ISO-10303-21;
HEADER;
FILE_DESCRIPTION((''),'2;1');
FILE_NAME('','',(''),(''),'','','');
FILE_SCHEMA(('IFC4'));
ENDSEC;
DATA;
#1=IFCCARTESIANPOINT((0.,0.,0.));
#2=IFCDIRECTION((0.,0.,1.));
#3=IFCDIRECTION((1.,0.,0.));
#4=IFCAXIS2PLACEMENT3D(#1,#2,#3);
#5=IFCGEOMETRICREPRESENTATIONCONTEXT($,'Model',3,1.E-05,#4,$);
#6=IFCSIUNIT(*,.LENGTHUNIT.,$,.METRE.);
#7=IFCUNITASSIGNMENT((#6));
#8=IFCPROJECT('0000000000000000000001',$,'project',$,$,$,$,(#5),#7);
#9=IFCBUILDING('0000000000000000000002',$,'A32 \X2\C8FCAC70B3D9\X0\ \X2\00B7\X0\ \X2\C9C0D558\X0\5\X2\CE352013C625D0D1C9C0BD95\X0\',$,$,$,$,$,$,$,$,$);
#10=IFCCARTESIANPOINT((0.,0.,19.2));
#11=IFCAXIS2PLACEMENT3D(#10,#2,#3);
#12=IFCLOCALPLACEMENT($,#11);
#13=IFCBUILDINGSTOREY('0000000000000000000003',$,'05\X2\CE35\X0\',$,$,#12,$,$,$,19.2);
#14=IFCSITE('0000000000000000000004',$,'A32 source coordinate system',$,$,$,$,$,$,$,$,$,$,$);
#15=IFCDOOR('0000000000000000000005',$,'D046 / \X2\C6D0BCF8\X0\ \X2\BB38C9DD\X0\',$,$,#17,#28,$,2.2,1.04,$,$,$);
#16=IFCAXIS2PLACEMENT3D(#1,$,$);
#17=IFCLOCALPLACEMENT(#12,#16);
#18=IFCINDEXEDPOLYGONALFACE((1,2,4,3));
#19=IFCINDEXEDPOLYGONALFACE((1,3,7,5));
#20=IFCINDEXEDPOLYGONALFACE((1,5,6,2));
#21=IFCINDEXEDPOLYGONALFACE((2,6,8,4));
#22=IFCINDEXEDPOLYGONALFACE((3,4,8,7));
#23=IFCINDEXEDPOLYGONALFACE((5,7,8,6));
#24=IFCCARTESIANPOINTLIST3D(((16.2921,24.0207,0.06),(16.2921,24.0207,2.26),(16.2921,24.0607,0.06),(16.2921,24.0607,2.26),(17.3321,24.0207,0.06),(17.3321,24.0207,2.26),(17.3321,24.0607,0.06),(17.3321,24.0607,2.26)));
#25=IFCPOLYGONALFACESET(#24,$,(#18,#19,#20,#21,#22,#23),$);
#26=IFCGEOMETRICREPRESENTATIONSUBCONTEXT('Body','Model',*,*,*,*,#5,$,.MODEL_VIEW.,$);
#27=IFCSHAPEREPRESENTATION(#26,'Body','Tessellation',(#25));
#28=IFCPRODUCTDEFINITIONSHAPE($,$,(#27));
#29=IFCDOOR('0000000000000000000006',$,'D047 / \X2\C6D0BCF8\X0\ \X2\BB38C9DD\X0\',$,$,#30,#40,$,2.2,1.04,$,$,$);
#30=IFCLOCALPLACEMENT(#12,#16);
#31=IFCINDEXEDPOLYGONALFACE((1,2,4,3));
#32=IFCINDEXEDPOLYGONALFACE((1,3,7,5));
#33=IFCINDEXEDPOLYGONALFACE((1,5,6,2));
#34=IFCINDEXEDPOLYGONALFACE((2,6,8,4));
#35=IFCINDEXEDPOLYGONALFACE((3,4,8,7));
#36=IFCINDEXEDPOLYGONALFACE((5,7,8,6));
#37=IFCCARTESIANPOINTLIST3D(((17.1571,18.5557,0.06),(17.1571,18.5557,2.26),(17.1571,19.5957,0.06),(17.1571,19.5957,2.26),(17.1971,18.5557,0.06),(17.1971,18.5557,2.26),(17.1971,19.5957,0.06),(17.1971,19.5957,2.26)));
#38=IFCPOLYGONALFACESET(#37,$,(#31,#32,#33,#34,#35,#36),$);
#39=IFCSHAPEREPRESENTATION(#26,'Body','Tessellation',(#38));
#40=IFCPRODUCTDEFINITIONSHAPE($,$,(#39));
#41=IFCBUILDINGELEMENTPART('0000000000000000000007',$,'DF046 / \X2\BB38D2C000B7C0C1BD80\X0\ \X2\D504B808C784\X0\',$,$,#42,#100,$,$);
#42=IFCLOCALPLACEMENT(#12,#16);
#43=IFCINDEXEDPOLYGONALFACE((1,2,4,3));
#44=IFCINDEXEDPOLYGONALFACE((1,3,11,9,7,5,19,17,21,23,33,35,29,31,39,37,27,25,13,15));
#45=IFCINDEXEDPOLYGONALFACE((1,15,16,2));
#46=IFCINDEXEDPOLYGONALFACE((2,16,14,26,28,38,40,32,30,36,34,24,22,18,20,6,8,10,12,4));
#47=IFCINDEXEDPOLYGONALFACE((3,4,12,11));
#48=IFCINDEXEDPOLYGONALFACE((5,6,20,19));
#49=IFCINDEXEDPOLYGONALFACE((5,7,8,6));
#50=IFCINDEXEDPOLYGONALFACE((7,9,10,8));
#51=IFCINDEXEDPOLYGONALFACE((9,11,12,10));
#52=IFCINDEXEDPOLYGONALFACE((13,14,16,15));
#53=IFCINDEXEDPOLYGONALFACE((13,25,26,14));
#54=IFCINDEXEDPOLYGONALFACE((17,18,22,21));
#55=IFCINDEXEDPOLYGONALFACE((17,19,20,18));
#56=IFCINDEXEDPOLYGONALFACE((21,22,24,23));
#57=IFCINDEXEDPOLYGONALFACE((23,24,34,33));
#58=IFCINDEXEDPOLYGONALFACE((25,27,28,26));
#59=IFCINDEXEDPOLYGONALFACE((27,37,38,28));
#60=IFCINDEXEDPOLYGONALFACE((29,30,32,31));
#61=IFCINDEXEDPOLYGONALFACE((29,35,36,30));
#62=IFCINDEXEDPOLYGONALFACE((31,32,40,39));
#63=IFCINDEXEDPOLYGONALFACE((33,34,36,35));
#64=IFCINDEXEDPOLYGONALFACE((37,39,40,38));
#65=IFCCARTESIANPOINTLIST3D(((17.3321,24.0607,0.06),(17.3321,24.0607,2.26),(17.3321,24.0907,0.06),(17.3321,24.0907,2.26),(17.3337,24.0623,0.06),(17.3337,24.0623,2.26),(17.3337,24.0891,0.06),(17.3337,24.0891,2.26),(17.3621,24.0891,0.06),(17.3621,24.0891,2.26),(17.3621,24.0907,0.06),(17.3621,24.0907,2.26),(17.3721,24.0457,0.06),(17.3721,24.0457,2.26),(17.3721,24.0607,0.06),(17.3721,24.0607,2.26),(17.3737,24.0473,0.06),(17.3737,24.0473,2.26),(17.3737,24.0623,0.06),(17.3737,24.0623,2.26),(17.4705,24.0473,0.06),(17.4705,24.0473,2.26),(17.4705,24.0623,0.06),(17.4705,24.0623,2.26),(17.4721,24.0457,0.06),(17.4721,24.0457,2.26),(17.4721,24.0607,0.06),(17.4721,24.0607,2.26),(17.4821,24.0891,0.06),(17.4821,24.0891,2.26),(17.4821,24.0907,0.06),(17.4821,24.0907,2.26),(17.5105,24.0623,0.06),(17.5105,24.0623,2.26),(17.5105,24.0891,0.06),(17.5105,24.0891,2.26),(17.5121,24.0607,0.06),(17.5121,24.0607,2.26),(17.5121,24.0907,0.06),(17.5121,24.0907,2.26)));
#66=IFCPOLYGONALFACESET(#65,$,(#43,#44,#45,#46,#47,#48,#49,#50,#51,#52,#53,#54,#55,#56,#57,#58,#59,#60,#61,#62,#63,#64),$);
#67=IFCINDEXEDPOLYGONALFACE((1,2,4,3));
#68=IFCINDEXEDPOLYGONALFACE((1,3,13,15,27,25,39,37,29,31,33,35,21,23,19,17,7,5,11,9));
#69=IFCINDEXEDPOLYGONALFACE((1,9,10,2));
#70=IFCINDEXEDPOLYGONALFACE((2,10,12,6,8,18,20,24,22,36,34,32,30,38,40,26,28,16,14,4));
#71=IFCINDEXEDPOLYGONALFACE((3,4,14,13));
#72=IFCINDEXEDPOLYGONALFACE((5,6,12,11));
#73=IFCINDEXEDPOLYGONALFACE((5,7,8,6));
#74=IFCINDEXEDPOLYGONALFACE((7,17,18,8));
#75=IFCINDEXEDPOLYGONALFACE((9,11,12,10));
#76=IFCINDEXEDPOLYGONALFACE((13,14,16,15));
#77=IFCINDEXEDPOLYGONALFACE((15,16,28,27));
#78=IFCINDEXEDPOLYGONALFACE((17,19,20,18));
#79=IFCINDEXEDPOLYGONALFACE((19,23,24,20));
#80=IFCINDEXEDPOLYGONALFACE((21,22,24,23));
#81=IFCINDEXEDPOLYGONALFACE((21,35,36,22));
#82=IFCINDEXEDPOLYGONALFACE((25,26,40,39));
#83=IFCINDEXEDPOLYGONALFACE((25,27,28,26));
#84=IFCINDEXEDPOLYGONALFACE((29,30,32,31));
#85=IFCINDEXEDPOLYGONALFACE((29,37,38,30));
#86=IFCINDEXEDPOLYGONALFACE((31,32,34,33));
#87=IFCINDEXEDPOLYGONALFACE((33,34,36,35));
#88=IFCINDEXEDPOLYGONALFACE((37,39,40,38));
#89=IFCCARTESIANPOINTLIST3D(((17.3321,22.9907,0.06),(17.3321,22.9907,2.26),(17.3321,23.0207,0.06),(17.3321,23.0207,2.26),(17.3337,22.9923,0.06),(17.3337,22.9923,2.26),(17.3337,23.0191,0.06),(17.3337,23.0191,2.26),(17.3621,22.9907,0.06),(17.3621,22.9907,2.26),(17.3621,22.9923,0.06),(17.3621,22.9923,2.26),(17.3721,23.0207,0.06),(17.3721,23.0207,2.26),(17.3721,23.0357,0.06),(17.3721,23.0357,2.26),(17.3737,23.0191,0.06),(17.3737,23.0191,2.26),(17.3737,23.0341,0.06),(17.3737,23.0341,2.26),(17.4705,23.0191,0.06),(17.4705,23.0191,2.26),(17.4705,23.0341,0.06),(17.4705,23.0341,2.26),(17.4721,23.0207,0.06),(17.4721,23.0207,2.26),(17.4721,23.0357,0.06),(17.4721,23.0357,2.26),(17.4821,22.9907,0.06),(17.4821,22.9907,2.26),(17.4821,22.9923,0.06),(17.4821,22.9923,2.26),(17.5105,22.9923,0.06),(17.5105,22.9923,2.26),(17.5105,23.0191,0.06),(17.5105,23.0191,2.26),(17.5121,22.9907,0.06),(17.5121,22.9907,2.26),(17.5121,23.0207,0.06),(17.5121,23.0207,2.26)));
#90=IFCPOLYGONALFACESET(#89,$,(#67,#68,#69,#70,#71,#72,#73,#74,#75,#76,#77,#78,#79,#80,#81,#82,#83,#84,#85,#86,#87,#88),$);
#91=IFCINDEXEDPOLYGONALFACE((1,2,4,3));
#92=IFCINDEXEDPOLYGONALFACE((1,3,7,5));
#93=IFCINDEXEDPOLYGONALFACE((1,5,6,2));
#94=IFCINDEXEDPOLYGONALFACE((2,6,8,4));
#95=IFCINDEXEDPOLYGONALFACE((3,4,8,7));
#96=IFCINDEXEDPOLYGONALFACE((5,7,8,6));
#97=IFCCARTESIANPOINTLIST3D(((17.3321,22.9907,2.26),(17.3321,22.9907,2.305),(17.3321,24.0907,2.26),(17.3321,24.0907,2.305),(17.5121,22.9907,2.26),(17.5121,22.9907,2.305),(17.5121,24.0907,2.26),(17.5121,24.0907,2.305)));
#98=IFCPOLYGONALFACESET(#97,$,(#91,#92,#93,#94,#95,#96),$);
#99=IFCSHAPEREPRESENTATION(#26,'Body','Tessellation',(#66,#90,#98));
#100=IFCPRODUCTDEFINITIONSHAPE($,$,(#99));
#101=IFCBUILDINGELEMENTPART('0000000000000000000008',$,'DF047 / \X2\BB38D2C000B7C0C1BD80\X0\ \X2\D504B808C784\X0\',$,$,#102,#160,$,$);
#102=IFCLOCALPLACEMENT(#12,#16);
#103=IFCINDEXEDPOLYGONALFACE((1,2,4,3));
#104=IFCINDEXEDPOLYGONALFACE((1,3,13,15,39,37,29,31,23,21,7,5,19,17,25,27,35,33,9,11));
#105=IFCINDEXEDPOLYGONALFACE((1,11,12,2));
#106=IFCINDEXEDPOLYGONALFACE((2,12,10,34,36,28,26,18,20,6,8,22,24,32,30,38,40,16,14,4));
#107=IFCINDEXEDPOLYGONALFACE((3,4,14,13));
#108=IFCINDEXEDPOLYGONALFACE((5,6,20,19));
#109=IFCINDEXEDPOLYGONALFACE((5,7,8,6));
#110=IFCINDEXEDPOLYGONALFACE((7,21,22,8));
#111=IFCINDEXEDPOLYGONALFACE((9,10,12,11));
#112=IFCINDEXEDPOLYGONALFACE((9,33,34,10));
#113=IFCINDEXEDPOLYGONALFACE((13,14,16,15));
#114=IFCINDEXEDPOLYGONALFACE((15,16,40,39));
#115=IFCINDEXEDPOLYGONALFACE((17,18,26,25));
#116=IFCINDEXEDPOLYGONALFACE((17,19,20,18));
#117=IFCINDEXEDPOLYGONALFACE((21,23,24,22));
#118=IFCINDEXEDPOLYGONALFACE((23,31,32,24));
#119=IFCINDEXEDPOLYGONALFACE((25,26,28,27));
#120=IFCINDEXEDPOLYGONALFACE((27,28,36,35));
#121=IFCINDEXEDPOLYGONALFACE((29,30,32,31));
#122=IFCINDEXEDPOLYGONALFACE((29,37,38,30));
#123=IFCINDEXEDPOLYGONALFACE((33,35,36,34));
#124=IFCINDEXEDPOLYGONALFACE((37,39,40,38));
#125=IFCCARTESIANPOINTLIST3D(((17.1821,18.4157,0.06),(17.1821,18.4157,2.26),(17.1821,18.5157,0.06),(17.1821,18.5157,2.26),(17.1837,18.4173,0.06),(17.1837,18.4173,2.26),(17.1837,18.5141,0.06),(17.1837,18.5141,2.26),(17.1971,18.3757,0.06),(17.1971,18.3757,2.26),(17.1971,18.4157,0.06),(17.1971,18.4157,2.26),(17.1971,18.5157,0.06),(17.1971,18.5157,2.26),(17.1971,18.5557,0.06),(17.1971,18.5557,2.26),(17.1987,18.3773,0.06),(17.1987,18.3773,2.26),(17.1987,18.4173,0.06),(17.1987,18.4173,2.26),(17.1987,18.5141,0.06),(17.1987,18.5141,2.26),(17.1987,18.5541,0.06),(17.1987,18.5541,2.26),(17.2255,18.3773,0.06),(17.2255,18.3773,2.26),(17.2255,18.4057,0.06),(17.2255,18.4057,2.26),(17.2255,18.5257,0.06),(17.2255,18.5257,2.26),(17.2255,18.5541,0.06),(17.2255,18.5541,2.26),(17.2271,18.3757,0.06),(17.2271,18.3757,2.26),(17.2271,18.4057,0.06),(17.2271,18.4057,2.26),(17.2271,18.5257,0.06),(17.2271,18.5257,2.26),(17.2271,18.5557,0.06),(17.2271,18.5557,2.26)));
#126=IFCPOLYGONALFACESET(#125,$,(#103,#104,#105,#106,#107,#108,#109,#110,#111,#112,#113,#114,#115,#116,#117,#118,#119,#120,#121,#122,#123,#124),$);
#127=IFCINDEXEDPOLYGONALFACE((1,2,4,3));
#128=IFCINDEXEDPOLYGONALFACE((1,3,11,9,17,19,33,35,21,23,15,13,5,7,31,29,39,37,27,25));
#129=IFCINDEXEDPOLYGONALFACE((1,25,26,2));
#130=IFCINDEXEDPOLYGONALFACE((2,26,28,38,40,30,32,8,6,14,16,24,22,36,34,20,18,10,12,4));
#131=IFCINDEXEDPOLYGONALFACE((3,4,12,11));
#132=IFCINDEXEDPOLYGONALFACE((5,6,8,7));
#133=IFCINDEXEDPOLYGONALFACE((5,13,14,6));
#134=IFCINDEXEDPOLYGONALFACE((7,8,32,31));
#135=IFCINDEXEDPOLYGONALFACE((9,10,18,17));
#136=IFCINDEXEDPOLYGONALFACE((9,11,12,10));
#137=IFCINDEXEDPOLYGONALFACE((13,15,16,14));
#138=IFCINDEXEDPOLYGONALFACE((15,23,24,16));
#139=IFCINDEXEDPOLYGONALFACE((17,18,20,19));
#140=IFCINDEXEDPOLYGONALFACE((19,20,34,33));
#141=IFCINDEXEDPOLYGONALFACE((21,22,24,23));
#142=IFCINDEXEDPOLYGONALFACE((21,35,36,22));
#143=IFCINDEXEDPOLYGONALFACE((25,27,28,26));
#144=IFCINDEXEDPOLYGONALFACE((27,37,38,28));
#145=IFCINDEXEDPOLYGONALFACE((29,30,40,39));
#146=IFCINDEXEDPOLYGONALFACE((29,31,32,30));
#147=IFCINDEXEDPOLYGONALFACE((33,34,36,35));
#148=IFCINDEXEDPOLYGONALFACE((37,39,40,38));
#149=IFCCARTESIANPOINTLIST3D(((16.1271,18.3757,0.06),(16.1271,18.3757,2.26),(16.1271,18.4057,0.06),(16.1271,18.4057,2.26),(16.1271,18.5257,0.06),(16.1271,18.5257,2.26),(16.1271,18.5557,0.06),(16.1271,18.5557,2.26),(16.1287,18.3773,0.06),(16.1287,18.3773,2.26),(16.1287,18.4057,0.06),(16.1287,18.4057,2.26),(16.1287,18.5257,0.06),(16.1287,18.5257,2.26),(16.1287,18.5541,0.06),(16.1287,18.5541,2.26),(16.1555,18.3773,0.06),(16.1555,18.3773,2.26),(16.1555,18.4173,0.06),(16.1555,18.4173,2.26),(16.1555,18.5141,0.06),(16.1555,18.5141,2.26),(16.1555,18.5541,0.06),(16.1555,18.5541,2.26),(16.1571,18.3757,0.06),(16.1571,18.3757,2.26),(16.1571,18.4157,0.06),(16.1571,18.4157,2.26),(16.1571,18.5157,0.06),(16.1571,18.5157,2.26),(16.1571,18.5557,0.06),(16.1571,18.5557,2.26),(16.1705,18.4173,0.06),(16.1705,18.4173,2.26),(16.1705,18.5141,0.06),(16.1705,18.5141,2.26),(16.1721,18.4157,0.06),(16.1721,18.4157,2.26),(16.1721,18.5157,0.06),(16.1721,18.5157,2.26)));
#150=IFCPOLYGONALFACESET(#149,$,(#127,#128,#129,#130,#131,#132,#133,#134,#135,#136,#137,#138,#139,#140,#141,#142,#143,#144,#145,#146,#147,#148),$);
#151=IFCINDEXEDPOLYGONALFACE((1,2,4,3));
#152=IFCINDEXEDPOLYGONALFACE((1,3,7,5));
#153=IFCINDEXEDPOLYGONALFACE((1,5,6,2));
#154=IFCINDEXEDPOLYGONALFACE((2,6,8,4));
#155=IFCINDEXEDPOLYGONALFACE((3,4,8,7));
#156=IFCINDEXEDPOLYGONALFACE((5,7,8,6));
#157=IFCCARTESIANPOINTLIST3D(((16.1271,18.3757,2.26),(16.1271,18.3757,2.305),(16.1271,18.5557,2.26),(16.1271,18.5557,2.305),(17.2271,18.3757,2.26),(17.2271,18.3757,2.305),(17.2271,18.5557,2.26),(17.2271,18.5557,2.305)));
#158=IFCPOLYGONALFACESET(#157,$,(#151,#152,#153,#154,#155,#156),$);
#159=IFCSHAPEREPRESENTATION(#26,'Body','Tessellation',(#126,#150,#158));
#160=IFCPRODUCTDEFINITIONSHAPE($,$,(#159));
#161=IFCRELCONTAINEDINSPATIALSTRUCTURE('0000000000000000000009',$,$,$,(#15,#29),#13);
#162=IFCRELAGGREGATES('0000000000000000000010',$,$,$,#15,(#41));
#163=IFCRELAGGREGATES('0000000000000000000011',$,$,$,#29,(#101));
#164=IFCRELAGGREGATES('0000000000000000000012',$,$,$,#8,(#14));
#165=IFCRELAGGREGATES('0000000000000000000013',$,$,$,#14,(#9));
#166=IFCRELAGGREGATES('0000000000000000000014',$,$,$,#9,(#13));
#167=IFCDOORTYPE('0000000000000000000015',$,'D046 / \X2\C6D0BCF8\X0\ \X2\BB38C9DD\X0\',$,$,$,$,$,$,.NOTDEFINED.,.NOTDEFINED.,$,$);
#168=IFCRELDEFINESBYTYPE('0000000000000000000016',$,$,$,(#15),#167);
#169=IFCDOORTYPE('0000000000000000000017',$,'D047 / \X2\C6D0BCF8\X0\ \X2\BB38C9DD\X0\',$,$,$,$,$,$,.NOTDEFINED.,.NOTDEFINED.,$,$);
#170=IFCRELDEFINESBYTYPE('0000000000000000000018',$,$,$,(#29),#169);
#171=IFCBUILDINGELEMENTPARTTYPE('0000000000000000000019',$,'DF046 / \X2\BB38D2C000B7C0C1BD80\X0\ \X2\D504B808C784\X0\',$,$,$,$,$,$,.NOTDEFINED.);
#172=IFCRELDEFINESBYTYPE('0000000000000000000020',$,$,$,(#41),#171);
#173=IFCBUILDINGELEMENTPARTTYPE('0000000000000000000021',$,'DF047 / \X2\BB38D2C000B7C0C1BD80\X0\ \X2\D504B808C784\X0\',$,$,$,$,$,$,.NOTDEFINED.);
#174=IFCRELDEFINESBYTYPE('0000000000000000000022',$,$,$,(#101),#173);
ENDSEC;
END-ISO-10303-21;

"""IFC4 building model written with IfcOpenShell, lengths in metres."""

from ifc_helpers import new_model, si_unit, frame, origin, origin_with_axes, place, context, subcontext, project, spatial, polyline, outline, extrude, source, transform, mapped, type_object, type_shapes, element, aggregate, save


model = new_model("IFC4")

# Units and contexts
model_context = context("Model", 3, precision=1e-05, world=origin_with_axes())
body_context = subcontext(model_context, "Body", "Model", "MODEL_VIEW")
ifc_project = project(units=[si_unit("LENGTHUNIT", "METRE")], contexts=[model_context])

# Site, building, storey
storey_placement = place(None, frame((0.0, 0.0, 19.2), z_axis=(0.0, 0.0, 1.0), x_axis=(1.0, 0.0, 0.0)))
site = spatial("IfcSite", under=ifc_project, Name="A32 source coordinate system")
building = spatial("IfcBuilding", under=site, Name="A32 주거동 · 지하5층–옥탑지붕")
storey = spatial("IfcBuildingStorey", under=building, at=storey_placement, Name="05층", Elevation=19.2)

# Doors
door_type_1 = type_object("IfcDoorType", Name="D046 / 원본 문짝", OperationType="NOTDEFINED", PredefinedType="NOTDEFINED")
shared_shape_1 = source(origin(), body_context, "Body", "SweptSolid", [
    extrude(outline(polyline([(17.3321, 24.0607), (17.3321, 24.0207), (16.2921, 24.0207), (16.2921, 24.0607), (17.3321, 24.0607)])), frame((0.0, 0.0, 0.06)), (0.0, 0.0, 1.0), 2.2),
])
type_shapes(door_type_1, [shared_shape_1])
door_1_placement = place(storey_placement, origin_with_axes())
door_1 = element("IfcDoor", 1, at=door_1_placement, inside=storey, type_object=door_type_1, Name="D046 / 원본 문짝", OverallHeight=2.2, OverallWidth=1.04, context=body_context, shape_type="MappedRepresentation", body=[
    mapped(shared_shape_1, transform((0.0, 0.0, 0.0), scale=1.0)),
])
door_type_2 = type_object("IfcDoorType", Name="D047 / 원본 문짝", OperationType="NOTDEFINED", PredefinedType="NOTDEFINED")
shared_shape_2 = source(origin(), body_context, "Body", "SweptSolid", [
    extrude(outline(polyline([(17.1971, 18.5557), (17.1571, 18.5557), (17.1571, 19.5957), (17.1971, 19.5957), (17.1971, 18.5557)])), frame((0.0, 0.0, 0.06)), (0.0, 0.0, 1.0), 2.2),
])
type_shapes(door_type_2, [shared_shape_2])
door_2_placement = place(storey_placement, origin_with_axes())
door_2 = element("IfcDoor", 2, at=door_2_placement, inside=storey, type_object=door_type_2, Name="D047 / 원본 문짝", OverallHeight=2.2, OverallWidth=1.04, context=body_context, shape_type="MappedRepresentation", body=[
    mapped(shared_shape_2, transform((0.0, 0.0, 0.0), scale=1.0)),
])

# Building element parts
building_element_part_type_1 = type_object("IfcBuildingElementPartType", Name="DF046 / 문틀·상부 프레임", PredefinedType="NOTDEFINED")
shared_shape_3 = source(origin(), body_context, "Body", "SweptSolid", [
    extrude(outline(polyline([(17.3337, 24.0891), (17.3337, 24.0623), (17.3737, 24.0623), (17.3737, 24.0473), (17.4705, 24.0473), (17.4705, 24.0623), (17.5105, 24.0623), (17.5105, 24.0891), (17.4821, 24.0891), (17.4821, 24.0907), (17.5121, 24.0907), (17.5121, 24.0607), (17.4721, 24.0607), (17.4721, 24.0457), (17.3721, 24.0457), (17.3721, 24.0607), (17.3321, 24.0607), (17.3321, 24.0907), (17.3621, 24.0907), (17.3621, 24.0891), (17.3337, 24.0891)])), frame((0.0, 0.0, 0.06)), (0.0, 0.0, 1.0), 2.2),
    extrude(outline(polyline([(17.3621, 22.9907), (17.3321, 22.9907), (17.3321, 23.0207), (17.3721, 23.0207), (17.3721, 23.0357), (17.4721, 23.0357), (17.4721, 23.0207), (17.5121, 23.0207), (17.5121, 22.9907), (17.4821, 22.9907), (17.4821, 22.9923), (17.5105, 22.9923), (17.5105, 23.0191), (17.4705, 23.0191), (17.4705, 23.0341), (17.3737, 23.0341), (17.3737, 23.0191), (17.3337, 23.0191), (17.3337, 22.9923), (17.3621, 22.9923), (17.3621, 22.9907)])), frame((0.0, 0.0, 0.06)), (0.0, 0.0, 1.0), 2.2),
    extrude(outline(polyline([(17.3321, 22.9907), (17.3321, 24.0907), (17.5121, 24.0907), (17.5121, 22.9907), (17.3321, 22.9907)])), frame((0.0, 0.0, 2.26)), (0.0, 0.0, 1.0), 0.045),
])
type_shapes(building_element_part_type_1, [shared_shape_3])
building_element_part_1_placement = place(door_1_placement, origin_with_axes())
building_element_part_1 = element("IfcBuildingElementPart", 3, at=building_element_part_1_placement, type_object=building_element_part_type_1, Name="DF046 / 문틀·상부 프레임", context=body_context, shape_type="MappedRepresentation", body=[
    mapped(shared_shape_3, transform((0.0, 0.0, 0.0), scale=1.0)),
])
aggregate(door_1, [building_element_part_1])
building_element_part_type_2 = type_object("IfcBuildingElementPartType", Name="DF047 / 문틀·상부 프레임", PredefinedType="NOTDEFINED")
shared_shape_4 = source(origin(), body_context, "Body", "SweptSolid", [
    extrude(outline(polyline([(17.2255, 18.5541), (17.1987, 18.5541), (17.1987, 18.5141), (17.1837, 18.5141), (17.1837, 18.4173), (17.1987, 18.4173), (17.1987, 18.3773), (17.2255, 18.3773), (17.2255, 18.4057), (17.2271, 18.4057), (17.2271, 18.3757), (17.1971, 18.3757), (17.1971, 18.4157), (17.1821, 18.4157), (17.1821, 18.5157), (17.1971, 18.5157), (17.1971, 18.5557), (17.2271, 18.5557), (17.2271, 18.5257), (17.2255, 18.5257), (17.2255, 18.5541)])), frame((0.0, 0.0, 0.06)), (0.0, 0.0, 1.0), 2.2),
    extrude(outline(polyline([(16.1271, 18.5257), (16.1271, 18.5557), (16.1571, 18.5557), (16.1571, 18.5157), (16.1721, 18.5157), (16.1721, 18.4157), (16.1571, 18.4157), (16.1571, 18.3757), (16.1271, 18.3757), (16.1271, 18.4057), (16.1287, 18.4057), (16.1287, 18.3773), (16.1555, 18.3773), (16.1555, 18.4173), (16.1705, 18.4173), (16.1705, 18.5141), (16.1555, 18.5141), (16.1555, 18.5541), (16.1287, 18.5541), (16.1287, 18.5257), (16.1271, 18.5257)])), frame((0.0, 0.0, 0.06)), (0.0, 0.0, 1.0), 2.2),
    extrude(outline(polyline([(16.1271, 18.3757), (16.1271, 18.5557), (17.2271, 18.5557), (17.2271, 18.3757), (16.1271, 18.3757)])), frame((0.0, 0.0, 2.26)), (0.0, 0.0, 1.0), 0.045),
])
type_shapes(building_element_part_type_2, [shared_shape_4])
building_element_part_2_placement = place(door_2_placement, origin_with_axes())
building_element_part_2 = element("IfcBuildingElementPart", 4, at=building_element_part_2_placement, type_object=building_element_part_type_2, Name="DF047 / 문틀·상부 프레임", context=body_context, shape_type="MappedRepresentation", body=[
    mapped(shared_shape_4, transform((0.0, 0.0, 0.0), scale=1.0)),
])
aggregate(door_2, [building_element_part_2])

save(model, "model.ifc")
